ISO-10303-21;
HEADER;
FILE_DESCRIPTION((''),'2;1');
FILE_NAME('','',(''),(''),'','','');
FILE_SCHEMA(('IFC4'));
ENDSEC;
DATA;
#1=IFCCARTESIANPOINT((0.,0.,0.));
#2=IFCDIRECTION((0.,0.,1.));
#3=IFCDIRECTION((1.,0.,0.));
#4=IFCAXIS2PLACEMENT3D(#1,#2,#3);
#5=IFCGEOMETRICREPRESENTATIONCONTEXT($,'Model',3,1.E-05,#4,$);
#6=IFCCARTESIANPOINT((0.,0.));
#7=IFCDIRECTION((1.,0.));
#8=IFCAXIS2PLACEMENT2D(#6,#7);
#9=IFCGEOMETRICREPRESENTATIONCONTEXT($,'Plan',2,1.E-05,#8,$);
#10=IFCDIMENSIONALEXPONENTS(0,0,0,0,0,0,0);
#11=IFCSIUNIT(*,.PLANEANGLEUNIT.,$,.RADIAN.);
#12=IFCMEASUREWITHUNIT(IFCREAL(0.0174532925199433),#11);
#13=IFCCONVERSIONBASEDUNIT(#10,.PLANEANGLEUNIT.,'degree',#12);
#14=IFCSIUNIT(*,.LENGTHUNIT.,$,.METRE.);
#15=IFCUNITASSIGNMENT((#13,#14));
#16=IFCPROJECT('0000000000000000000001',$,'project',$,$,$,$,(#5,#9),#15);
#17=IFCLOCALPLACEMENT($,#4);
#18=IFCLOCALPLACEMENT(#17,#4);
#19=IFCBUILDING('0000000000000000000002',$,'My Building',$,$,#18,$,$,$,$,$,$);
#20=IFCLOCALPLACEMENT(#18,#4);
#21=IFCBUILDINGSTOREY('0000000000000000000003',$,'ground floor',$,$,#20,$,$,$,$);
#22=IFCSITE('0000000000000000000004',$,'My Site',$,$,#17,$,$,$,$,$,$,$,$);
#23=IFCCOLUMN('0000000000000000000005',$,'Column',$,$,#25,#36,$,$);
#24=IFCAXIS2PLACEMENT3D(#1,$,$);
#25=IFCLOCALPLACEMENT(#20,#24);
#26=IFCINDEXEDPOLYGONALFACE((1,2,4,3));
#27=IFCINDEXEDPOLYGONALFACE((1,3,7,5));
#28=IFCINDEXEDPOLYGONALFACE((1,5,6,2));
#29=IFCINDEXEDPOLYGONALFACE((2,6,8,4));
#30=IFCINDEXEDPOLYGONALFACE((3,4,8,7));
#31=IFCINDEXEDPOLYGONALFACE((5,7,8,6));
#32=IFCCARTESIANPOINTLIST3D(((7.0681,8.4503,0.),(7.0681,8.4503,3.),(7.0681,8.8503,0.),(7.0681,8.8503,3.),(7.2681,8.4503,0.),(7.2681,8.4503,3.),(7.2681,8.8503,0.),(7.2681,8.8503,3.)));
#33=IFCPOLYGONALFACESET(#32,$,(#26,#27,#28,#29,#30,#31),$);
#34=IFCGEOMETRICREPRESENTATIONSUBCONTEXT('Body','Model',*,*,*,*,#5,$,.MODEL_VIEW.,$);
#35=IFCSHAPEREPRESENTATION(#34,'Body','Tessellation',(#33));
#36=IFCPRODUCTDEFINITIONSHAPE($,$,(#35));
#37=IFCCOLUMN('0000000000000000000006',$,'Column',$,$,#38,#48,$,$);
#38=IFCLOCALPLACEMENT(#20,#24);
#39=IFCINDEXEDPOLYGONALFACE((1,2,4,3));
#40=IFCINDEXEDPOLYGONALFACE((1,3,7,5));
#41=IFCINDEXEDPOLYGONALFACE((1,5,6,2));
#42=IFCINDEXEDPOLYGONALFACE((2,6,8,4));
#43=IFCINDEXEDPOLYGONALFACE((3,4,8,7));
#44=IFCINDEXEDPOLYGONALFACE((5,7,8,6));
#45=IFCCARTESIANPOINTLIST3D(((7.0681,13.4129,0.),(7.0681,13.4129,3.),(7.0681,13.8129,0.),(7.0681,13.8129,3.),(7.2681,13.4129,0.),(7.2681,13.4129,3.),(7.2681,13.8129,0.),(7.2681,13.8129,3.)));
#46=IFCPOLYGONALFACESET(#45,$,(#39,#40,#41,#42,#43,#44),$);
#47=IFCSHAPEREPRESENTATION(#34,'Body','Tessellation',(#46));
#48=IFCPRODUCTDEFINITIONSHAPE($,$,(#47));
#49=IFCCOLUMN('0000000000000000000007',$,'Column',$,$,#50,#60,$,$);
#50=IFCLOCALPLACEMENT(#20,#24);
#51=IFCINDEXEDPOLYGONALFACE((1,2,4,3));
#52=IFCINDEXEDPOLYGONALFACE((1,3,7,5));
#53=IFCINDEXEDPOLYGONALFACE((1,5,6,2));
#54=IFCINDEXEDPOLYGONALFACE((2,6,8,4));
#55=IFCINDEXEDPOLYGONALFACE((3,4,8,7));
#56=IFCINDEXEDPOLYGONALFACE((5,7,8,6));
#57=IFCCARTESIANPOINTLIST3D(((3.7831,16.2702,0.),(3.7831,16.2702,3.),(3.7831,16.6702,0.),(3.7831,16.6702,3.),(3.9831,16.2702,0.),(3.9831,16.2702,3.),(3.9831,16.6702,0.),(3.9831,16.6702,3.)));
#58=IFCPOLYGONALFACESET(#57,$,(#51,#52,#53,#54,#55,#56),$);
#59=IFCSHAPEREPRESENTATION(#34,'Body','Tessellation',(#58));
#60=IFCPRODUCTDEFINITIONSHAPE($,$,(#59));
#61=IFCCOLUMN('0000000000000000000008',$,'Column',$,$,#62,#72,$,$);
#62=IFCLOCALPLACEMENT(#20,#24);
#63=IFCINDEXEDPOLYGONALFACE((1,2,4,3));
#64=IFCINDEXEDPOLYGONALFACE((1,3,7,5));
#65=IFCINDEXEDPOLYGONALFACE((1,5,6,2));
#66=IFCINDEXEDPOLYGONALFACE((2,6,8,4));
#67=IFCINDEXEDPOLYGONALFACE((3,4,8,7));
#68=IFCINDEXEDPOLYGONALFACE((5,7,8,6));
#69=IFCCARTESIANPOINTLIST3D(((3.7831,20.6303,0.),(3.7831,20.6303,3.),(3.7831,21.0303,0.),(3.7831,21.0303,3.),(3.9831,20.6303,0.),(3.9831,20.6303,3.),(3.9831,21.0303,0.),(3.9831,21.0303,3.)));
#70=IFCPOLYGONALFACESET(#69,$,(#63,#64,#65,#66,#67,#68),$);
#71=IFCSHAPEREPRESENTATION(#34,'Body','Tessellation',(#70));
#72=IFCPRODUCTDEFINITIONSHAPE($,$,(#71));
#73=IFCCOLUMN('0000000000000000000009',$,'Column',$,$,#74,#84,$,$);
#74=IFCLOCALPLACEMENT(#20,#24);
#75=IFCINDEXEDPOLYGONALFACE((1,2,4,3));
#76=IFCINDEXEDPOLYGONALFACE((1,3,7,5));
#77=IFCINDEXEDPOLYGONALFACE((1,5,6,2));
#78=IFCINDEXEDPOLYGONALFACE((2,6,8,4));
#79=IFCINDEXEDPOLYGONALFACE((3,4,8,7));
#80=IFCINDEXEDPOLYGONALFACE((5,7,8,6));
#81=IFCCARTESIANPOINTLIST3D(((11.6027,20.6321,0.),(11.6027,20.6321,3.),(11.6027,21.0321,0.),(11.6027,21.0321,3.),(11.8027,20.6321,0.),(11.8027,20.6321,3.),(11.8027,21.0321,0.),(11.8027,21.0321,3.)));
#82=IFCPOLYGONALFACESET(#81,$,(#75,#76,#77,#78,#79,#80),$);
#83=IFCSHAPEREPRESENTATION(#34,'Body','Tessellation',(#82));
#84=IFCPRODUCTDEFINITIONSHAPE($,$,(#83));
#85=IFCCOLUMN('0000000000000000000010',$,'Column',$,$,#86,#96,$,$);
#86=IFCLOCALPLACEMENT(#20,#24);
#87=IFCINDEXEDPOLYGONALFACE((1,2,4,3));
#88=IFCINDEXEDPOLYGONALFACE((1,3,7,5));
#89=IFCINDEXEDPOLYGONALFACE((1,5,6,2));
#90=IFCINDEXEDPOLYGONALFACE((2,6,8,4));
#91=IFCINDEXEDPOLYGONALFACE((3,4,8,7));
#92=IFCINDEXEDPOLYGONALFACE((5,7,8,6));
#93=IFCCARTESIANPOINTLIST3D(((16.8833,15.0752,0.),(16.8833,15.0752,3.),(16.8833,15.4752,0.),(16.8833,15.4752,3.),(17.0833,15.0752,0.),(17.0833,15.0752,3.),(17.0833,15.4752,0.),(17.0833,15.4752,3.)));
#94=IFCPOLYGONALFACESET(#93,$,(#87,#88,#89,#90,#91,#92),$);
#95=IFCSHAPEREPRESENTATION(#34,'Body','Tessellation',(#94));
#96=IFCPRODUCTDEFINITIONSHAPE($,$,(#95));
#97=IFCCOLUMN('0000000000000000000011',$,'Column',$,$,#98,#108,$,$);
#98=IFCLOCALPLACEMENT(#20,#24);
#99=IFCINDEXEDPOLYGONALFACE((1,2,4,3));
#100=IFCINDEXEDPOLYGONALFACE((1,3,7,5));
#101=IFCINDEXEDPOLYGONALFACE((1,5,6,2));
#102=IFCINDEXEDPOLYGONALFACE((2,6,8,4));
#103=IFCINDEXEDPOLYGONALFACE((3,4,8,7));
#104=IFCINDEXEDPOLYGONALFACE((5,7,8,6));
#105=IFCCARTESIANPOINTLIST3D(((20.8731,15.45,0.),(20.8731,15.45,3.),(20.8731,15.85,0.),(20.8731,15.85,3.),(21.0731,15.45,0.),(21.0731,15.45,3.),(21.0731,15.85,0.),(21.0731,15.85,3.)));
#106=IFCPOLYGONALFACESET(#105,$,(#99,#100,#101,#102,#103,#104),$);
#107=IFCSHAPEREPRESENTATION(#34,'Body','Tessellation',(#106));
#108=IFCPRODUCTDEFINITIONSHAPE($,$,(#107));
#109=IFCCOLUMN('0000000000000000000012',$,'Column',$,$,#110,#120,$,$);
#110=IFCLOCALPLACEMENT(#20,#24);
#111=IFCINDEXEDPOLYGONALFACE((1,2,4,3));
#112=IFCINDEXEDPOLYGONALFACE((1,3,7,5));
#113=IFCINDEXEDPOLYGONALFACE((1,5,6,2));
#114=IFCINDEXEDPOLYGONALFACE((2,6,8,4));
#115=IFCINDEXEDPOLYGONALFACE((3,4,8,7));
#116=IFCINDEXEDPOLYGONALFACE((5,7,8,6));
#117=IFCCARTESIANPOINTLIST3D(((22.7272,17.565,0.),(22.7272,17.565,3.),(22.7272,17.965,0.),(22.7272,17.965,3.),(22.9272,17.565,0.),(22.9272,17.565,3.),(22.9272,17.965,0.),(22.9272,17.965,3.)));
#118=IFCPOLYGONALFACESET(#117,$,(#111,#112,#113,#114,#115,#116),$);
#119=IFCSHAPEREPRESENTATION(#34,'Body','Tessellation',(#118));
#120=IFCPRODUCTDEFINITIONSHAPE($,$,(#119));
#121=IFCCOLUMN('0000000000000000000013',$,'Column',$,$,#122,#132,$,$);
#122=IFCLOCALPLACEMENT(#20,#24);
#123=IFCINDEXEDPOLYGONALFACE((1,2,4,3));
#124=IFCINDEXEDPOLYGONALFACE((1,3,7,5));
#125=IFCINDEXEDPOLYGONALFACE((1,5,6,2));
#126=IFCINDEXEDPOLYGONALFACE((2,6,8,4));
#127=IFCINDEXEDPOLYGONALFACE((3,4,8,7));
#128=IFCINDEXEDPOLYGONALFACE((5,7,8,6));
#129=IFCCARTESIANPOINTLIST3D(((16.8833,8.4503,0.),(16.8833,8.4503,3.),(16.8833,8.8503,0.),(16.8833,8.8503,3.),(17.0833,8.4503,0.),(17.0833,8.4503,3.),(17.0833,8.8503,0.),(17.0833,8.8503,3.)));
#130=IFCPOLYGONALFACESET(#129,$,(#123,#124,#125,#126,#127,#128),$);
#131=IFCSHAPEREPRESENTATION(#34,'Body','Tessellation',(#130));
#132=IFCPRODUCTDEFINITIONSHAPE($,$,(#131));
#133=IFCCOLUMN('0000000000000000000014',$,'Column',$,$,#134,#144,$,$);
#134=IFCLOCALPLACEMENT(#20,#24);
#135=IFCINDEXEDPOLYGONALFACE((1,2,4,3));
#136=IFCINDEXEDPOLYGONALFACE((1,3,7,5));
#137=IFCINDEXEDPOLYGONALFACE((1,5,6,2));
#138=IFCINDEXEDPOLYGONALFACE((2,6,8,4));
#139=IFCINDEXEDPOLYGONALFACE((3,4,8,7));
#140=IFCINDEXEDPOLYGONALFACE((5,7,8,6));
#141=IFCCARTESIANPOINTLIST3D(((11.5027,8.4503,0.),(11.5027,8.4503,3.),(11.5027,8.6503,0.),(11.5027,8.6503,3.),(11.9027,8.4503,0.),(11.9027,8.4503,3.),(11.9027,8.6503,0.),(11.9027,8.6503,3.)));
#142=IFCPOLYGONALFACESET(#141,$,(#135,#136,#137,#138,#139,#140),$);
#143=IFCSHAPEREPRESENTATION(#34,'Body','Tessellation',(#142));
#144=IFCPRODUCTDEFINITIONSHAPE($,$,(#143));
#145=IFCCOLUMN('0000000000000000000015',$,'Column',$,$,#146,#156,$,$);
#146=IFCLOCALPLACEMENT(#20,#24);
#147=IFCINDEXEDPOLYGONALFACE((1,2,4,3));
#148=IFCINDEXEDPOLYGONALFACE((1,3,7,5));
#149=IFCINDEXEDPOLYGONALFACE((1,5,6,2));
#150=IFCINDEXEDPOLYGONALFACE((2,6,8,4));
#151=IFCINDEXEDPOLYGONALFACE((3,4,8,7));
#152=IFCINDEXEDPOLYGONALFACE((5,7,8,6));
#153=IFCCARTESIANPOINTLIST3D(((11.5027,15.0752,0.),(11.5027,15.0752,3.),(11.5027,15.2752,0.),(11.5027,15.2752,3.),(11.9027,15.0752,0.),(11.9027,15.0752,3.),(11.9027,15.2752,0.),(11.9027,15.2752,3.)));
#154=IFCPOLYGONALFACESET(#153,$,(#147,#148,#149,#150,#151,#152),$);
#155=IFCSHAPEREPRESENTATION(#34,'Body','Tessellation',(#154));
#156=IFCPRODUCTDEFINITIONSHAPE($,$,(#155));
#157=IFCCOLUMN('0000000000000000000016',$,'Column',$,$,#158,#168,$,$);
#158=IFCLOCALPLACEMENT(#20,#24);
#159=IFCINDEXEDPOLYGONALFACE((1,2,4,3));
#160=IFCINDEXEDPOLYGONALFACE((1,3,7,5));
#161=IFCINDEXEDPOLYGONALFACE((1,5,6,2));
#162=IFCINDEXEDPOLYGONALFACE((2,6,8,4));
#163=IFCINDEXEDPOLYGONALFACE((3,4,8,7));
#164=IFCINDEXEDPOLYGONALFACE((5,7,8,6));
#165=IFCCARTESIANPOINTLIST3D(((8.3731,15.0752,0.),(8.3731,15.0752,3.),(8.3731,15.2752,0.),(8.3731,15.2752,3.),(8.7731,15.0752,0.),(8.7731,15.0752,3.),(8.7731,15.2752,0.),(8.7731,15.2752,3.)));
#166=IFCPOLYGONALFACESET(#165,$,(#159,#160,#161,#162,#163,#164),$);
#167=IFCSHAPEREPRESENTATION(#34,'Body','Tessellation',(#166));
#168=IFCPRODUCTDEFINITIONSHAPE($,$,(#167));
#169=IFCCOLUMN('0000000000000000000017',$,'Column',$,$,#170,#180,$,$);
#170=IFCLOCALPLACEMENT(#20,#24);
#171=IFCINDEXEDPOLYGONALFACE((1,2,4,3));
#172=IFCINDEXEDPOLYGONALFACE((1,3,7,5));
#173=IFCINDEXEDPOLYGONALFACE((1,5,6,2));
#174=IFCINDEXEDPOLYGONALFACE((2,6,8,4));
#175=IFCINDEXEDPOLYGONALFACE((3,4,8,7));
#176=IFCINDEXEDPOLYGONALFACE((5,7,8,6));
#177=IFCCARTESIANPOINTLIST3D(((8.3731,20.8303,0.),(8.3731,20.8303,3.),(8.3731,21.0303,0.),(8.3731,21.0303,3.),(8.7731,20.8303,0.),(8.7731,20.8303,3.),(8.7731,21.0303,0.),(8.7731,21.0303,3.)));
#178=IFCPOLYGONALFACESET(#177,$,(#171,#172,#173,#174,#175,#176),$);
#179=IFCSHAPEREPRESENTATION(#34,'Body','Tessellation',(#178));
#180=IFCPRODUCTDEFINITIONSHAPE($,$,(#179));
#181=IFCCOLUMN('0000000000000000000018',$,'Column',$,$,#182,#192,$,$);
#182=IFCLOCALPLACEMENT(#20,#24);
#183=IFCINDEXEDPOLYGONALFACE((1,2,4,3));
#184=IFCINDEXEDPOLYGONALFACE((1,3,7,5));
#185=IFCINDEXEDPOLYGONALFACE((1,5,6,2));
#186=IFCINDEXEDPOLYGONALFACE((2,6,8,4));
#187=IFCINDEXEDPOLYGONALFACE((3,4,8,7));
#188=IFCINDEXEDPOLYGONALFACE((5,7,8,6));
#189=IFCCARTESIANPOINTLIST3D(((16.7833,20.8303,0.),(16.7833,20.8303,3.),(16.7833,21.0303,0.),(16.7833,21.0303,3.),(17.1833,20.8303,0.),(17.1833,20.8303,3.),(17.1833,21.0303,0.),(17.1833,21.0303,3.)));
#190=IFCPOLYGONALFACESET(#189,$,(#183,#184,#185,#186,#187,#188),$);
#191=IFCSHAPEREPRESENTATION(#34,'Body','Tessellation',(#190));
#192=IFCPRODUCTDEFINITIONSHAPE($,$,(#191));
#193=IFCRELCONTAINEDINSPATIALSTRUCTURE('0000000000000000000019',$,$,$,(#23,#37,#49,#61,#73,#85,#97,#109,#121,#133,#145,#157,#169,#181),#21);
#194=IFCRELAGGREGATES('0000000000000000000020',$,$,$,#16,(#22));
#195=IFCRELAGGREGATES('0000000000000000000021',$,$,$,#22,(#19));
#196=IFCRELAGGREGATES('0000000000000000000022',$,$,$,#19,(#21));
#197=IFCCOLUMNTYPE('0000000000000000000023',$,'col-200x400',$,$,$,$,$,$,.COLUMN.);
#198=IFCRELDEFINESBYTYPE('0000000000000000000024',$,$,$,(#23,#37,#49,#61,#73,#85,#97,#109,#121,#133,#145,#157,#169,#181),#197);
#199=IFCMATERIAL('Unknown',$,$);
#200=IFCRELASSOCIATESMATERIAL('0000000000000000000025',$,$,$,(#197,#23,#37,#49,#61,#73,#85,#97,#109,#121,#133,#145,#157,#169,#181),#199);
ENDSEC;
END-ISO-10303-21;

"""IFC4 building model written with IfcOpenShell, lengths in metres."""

from ifc_helpers import new_model, entity, si_unit, converted_unit, frame, origin_with_axes, origin_2d_with_axis, place, context, subcontext, project, spatial, rectangle, extrude, material, material_profile, profile_set, profile_usage, type_object, element, save


model = new_model("IFC4")

# Units and contexts
model_context = context("Model", 3, precision=1e-05, world=origin_with_axes())
plan_context = context("Plan", 2, precision=1e-05, world=origin_2d_with_axis())
body_context = subcontext(model_context, "Body", "Model", "MODEL_VIEW")
ifc_project = project(units=[converted_unit("PLANEANGLEUNIT", "degree", entity("IfcReal", 0.0174532925199433), si_unit("PLANEANGLEUNIT", "RADIAN"), dimensions=[0, 0, 0, 0, 0, 0, 0]), si_unit("LENGTHUNIT", "METRE")], contexts=[model_context, plan_context])

# Site, building, storey
site_placement = place(None, origin_with_axes())
site = spatial("IfcSite", under=ifc_project, at=site_placement, Name="My Site")
building_placement = place(site_placement, origin_with_axes())
building = spatial("IfcBuilding", under=site, at=building_placement, Name="My Building")
storey_placement = place(building_placement, origin_with_axes())
storey = spatial("IfcBuildingStorey", under=building, at=storey_placement, Name="ground floor")

# Columns
ifc_material = material(Name="Unknown")
ifc_material_profile_1 = material_profile(ifc_material, rectangle(XDim=0.2, YDim=0.4))
ifc_profile_set_1 = profile_set([ifc_material_profile_1])
ifc_profile_usage_1 = profile_usage(ifc_profile_set_1, cardinal=1)
column_type_1 = type_object("IfcColumnType", Name="col-200x400", PredefinedType="COLUMN", material=ifc_profile_set_1)
column_1_placement = place(storey_placement, frame((7.2681, 8.4503, 0.0), z_axis=(0.0, 0.0, 1.0), x_axis=(1.0, 0.0, 0.0)))
element("IfcColumn", 1, at=column_1_placement, inside=storey, type_object=column_type_1, material=ifc_profile_usage_1, Name="Column", context=body_context, shape_type="SweptSolid", body=[
    extrude(rectangle(XDim=0.2, YDim=0.4), frame((-0.1, 0.2, 0.0), z_axis=(0.0, 0.0, 1.0), x_axis=(1.0, 0.0, 0.0)), (0.0, 0.0, 1.0), 3.0),
])
ifc_profile_usage_2 = profile_usage(ifc_profile_set_1, cardinal=1)
column_2_placement = place(storey_placement, frame((7.2681, 13.4129, 0.0), z_axis=(0.0, 0.0, 1.0), x_axis=(1.0, 0.0, 0.0)))
element("IfcColumn", 2, at=column_2_placement, inside=storey, type_object=column_type_1, material=ifc_profile_usage_2, Name="Column", context=body_context, shape_type="SweptSolid", body=[
    extrude(rectangle(XDim=0.2, YDim=0.4), frame((-0.1, 0.2, 0.0), z_axis=(0.0, 0.0, 1.0), x_axis=(1.0, 0.0, 0.0)), (0.0, 0.0, 1.0), 3.0),
])
ifc_profile_usage_3 = profile_usage(ifc_profile_set_1, cardinal=1)
column_3_placement = place(storey_placement, frame((3.9831, 16.2702, 0.0), z_axis=(0.0, 0.0, 1.0), x_axis=(1.0, 0.0, 0.0)))
element("IfcColumn", 3, at=column_3_placement, inside=storey, type_object=column_type_1, material=ifc_profile_usage_3, Name="Column", context=body_context, shape_type="SweptSolid", body=[
    extrude(rectangle(XDim=0.2, YDim=0.4), frame((-0.1, 0.2, 0.0), z_axis=(0.0, 0.0, 1.0), x_axis=(1.0, 0.0, 0.0)), (0.0, 0.0, 1.0), 3.0),
])
ifc_profile_usage_4 = profile_usage(ifc_profile_set_1, cardinal=1)
column_4_placement = place(storey_placement, frame((3.9831, 20.6303, 0.0), z_axis=(0.0, 0.0, 1.0), x_axis=(1.0, 0.0, 0.0)))
element("IfcColumn", 4, at=column_4_placement, inside=storey, type_object=column_type_1, material=ifc_profile_usage_4, Name="Column", context=body_context, shape_type="SweptSolid", body=[
    extrude(rectangle(XDim=0.2, YDim=0.4), frame((-0.1, 0.2, 0.0), z_axis=(0.0, 0.0, 1.0), x_axis=(1.0, 0.0, 0.0)), (0.0, 0.0, 1.0), 3.0),
])
ifc_profile_usage_5 = profile_usage(ifc_profile_set_1, cardinal=1)
column_5_placement = place(storey_placement, frame((11.8027, 20.6321, 0.0), z_axis=(0.0, 0.0, 1.0), x_axis=(1.0, 0.0, 0.0)))
element("IfcColumn", 5, at=column_5_placement, inside=storey, type_object=column_type_1, material=ifc_profile_usage_5, Name="Column", context=body_context, shape_type="SweptSolid", body=[
    extrude(rectangle(XDim=0.2, YDim=0.4), frame((-0.1, 0.2, 0.0), z_axis=(0.0, 0.0, 1.0), x_axis=(1.0, 0.0, 0.0)), (0.0, 0.0, 1.0), 3.0),
])
ifc_profile_usage_6 = profile_usage(ifc_profile_set_1, cardinal=1)
column_6_placement = place(storey_placement, frame((17.0833, 15.0752, 0.0), z_axis=(0.0, 0.0, 1.0), x_axis=(1.0, 0.0, 0.0)))
element("IfcColumn", 6, at=column_6_placement, inside=storey, type_object=column_type_1, material=ifc_profile_usage_6, Name="Column", context=body_context, shape_type="SweptSolid", body=[
    extrude(rectangle(XDim=0.2, YDim=0.4), frame((-0.1, 0.2, 0.0), z_axis=(0.0, 0.0, 1.0), x_axis=(1.0, 0.0, 0.0)), (0.0, 0.0, 1.0), 3.0),
])
ifc_profile_usage_7 = profile_usage(ifc_profile_set_1, cardinal=1)
column_7_placement = place(storey_placement, frame((21.0731, 15.45, 0.0), z_axis=(0.0, 0.0, 1.0), x_axis=(1.0, 0.0, 0.0)))
element("IfcColumn", 7, at=column_7_placement, inside=storey, type_object=column_type_1, material=ifc_profile_usage_7, Name="Column", context=body_context, shape_type="SweptSolid", body=[
    extrude(rectangle(XDim=0.2, YDim=0.4), frame((-0.1, 0.2, 0.0), z_axis=(0.0, 0.0, 1.0), x_axis=(1.0, 0.0, 0.0)), (0.0, 0.0, 1.0), 3.0),
])
ifc_profile_usage_8 = profile_usage(ifc_profile_set_1, cardinal=1)
column_8_placement = place(storey_placement, frame((22.9272, 17.565, 0.0), z_axis=(0.0, 0.0, 1.0), x_axis=(1.0, 0.0, 0.0)))
element("IfcColumn", 8, at=column_8_placement, inside=storey, type_object=column_type_1, material=ifc_profile_usage_8, Name="Column", context=body_context, shape_type="SweptSolid", body=[
    extrude(rectangle(XDim=0.2, YDim=0.4), frame((-0.1, 0.2, 0.0), z_axis=(0.0, 0.0, 1.0), x_axis=(1.0, 0.0, 0.0)), (0.0, 0.0, 1.0), 3.0),
])
ifc_profile_usage_9 = profile_usage(ifc_profile_set_1, cardinal=1)
column_9_placement = place(storey_placement, frame((17.0833, 8.4503, 0.0), z_axis=(0.0, 0.0, 1.0), x_axis=(1.0, 0.0, 0.0)))
element("IfcColumn", 9, at=column_9_placement, inside=storey, type_object=column_type_1, material=ifc_profile_usage_9, Name="Column", context=body_context, shape_type="SweptSolid", body=[
    extrude(rectangle(XDim=0.2, YDim=0.4), frame((-0.1, 0.2, 0.0), z_axis=(0.0, 0.0, 1.0), x_axis=(1.0, 0.0, 0.0)), (0.0, 0.0, 1.0), 3.0),
])
ifc_profile_usage_10 = profile_usage(ifc_profile_set_1, cardinal=1)
column_10_placement = place(storey_placement, frame((11.5027, 8.4503, 0.0), z_axis=(0.0, 0.0, 1.0), x_axis=(0.0, -1.0, 0.0)))
element("IfcColumn", 10, at=column_10_placement, inside=storey, type_object=column_type_1, material=ifc_profile_usage_10, Name="Column", context=body_context, shape_type="SweptSolid", body=[
    extrude(rectangle(XDim=0.2, YDim=0.4), frame((-0.1, 0.2, 0.0), z_axis=(0.0, 0.0, 1.0), x_axis=(1.0, 0.0, 0.0)), (0.0, 0.0, 1.0), 3.0),
])
ifc_profile_usage_11 = profile_usage(ifc_profile_set_1, cardinal=1)
column_11_placement = place(storey_placement, frame((11.5027, 15.0752, 0.0), z_axis=(0.0, 0.0, 1.0), x_axis=(0.0, -1.0, 0.0)))
element("IfcColumn", 11, at=column_11_placement, inside=storey, type_object=column_type_1, material=ifc_profile_usage_11, Name="Column", context=body_context, shape_type="SweptSolid", body=[
    extrude(rectangle(XDim=0.2, YDim=0.4), frame((-0.1, 0.2, 0.0), z_axis=(0.0, 0.0, 1.0), x_axis=(1.0, 0.0, 0.0)), (0.0, 0.0, 1.0), 3.0),
])
ifc_profile_usage_12 = profile_usage(ifc_profile_set_1, cardinal=1)
column_12_placement = place(storey_placement, frame((8.3731, 15.0752, 0.0), z_axis=(0.0, 0.0, 1.0), x_axis=(0.0, -1.0, 0.0)))
element("IfcColumn", 12, at=column_12_placement, inside=storey, type_object=column_type_1, material=ifc_profile_usage_12, Name="Column", context=body_context, shape_type="SweptSolid", body=[
    extrude(rectangle(XDim=0.2, YDim=0.4), frame((-0.1, 0.2, 0.0), z_axis=(0.0, 0.0, 1.0), x_axis=(1.0, 0.0, 0.0)), (0.0, 0.0, 1.0), 3.0),
])
ifc_profile_usage_13 = profile_usage(ifc_profile_set_1, cardinal=1)
column_13_placement = place(storey_placement, frame((8.3731, 20.8303, 0.0), z_axis=(0.0, 0.0, 1.0), x_axis=(0.0, -1.0, 0.0)))
element("IfcColumn", 13, at=column_13_placement, inside=storey, type_object=column_type_1, material=ifc_profile_usage_13, Name="Column", context=body_context, shape_type="SweptSolid", body=[
    extrude(rectangle(XDim=0.2, YDim=0.4), frame((-0.1, 0.2, 0.0), z_axis=(0.0, 0.0, 1.0), x_axis=(1.0, 0.0, 0.0)), (0.0, 0.0, 1.0), 3.0),
])
ifc_profile_usage_14 = profile_usage(ifc_profile_set_1, cardinal=1)
column_14_placement = place(storey_placement, frame((16.7833, 20.8303, 0.0), z_axis=(0.0, 0.0, 1.0), x_axis=(0.0, -1.0, 0.0)))
element("IfcColumn", 14, at=column_14_placement, inside=storey, type_object=column_type_1, material=ifc_profile_usage_14, Name="Column", context=body_context, shape_type="SweptSolid", body=[
    extrude(rectangle(XDim=0.2, YDim=0.4), frame((-0.1, 0.2, 0.0), z_axis=(0.0, 0.0, 1.0), x_axis=(1.0, 0.0, 0.0)), (0.0, 0.0, 1.0), 3.0),
])

save(model, "model.ifc")
